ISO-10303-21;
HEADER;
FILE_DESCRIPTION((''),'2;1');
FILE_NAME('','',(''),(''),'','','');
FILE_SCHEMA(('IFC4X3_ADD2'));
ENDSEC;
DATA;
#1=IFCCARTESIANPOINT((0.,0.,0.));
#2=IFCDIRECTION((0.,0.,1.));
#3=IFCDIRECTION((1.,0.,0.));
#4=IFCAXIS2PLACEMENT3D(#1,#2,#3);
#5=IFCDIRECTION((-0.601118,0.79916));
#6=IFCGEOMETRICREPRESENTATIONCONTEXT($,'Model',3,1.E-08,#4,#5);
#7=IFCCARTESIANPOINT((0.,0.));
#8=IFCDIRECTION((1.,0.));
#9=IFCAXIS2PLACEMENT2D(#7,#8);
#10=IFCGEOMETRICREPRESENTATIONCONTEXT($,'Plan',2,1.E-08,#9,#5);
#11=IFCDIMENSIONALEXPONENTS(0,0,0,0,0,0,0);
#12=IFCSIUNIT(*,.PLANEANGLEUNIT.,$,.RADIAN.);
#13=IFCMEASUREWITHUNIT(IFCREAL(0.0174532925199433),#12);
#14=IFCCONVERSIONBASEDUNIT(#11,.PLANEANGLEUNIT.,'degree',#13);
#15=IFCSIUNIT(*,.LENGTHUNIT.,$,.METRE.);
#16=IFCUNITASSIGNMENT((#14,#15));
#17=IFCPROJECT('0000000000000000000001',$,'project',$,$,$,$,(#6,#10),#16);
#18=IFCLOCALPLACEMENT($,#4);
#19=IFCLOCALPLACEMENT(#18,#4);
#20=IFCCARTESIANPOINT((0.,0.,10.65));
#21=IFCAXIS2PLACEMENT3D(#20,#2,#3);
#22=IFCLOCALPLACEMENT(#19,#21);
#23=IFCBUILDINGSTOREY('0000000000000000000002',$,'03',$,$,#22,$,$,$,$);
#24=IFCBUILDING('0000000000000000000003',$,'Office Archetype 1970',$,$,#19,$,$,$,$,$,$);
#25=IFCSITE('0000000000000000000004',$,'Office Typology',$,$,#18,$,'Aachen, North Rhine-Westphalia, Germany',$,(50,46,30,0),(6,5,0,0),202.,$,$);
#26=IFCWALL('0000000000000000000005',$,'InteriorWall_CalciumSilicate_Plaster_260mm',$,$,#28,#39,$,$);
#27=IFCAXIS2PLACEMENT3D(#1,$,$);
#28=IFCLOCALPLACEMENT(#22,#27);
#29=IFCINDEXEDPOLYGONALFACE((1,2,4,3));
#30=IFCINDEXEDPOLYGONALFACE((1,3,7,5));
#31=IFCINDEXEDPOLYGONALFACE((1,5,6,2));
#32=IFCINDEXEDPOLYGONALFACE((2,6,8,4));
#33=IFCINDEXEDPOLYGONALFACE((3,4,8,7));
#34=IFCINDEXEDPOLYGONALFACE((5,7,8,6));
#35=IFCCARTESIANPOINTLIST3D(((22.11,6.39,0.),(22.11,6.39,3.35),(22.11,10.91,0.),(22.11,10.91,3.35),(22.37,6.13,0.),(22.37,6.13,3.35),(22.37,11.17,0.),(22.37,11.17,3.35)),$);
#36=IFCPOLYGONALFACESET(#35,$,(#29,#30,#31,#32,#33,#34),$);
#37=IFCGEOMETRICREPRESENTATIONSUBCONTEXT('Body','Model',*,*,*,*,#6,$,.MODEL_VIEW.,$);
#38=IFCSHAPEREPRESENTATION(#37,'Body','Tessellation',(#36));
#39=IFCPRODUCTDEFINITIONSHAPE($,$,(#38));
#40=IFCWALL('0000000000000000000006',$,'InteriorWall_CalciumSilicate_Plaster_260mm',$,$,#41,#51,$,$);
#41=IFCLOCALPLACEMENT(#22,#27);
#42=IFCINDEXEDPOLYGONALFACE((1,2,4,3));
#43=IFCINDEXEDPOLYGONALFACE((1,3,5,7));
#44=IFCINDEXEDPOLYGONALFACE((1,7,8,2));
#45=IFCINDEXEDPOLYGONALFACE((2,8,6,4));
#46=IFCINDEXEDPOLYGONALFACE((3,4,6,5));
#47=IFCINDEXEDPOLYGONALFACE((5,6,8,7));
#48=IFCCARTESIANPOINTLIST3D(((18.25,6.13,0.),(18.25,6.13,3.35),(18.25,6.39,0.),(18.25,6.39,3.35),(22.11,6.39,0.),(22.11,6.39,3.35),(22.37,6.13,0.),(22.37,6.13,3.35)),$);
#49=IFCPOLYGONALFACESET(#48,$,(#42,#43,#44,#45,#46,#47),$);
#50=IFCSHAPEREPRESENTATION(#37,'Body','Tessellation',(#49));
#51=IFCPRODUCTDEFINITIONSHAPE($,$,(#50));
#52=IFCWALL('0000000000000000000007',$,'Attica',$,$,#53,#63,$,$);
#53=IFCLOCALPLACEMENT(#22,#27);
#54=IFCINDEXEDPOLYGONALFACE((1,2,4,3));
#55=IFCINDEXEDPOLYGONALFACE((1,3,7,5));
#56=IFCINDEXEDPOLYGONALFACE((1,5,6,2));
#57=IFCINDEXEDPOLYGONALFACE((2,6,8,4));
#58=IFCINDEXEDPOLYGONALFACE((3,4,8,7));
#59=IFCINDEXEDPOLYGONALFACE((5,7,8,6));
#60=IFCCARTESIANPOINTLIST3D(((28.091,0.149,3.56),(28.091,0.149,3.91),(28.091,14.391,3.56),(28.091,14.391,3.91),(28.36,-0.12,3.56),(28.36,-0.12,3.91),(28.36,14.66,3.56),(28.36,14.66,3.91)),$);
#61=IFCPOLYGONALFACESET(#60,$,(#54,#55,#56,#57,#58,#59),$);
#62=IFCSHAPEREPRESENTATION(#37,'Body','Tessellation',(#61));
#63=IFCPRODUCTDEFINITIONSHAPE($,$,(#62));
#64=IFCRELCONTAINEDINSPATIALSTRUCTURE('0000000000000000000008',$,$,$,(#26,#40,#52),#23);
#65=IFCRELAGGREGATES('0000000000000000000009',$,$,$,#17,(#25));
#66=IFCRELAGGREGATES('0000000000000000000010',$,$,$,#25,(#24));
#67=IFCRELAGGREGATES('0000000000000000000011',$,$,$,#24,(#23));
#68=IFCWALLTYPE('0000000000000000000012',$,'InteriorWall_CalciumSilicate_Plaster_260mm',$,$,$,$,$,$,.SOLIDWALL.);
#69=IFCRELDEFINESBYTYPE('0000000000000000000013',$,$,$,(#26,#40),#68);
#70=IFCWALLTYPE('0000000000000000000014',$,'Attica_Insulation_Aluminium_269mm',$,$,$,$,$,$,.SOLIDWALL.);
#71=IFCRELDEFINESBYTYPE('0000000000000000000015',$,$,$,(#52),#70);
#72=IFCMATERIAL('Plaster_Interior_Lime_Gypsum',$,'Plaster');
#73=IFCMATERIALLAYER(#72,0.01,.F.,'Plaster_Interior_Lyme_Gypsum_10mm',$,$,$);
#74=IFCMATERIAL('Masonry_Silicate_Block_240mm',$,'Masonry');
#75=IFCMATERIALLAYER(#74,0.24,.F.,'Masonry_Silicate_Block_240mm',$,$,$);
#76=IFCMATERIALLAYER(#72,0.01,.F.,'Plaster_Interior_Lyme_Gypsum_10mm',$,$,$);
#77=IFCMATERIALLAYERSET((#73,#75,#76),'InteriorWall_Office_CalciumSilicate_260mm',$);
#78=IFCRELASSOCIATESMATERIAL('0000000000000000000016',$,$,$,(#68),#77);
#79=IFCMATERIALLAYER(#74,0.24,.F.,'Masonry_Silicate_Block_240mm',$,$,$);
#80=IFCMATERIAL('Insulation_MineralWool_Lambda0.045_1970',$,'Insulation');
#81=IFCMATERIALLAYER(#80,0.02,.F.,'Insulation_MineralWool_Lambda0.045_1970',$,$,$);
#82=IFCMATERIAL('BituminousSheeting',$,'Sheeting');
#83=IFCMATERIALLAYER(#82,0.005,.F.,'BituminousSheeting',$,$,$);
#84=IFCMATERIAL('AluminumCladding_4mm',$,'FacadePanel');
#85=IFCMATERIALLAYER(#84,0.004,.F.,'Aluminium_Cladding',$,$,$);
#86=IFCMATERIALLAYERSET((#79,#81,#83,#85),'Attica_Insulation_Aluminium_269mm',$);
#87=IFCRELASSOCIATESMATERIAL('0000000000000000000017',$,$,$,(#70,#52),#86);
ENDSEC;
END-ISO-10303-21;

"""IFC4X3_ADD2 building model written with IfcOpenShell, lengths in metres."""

from ifc_helpers import new_model, entity, si_unit, converted_unit, direction, frame, origin_with_axes, origin_2d_with_axis, place, context, subcontext, project, spatial, line, indexed_curve, outline, extrude, material, layer, layer_set, layer_usage, type_object, element, save


model = new_model("IFC4X3_ADD2")

# Units and contexts
model_context = context("Model", 3, precision=1e-08, world=origin_with_axes(), true_north=direction((-0.601118, 0.79916)))
plan_context = context("Plan", 2, precision=1e-08, world=origin_2d_with_axis(), true_north=direction((-0.601118, 0.79916)))
body_context = subcontext(model_context, "Body", "Model", "MODEL_VIEW")
ifc_project = project(units=[converted_unit("PLANEANGLEUNIT", "degree", entity("IfcReal", 0.0174532925199433), si_unit("PLANEANGLEUNIT", "RADIAN"), dimensions=[0, 0, 0, 0, 0, 0, 0]), si_unit("LENGTHUNIT", "METRE")], contexts=[model_context, plan_context])

# Site, building, storey
site_placement = place(None, origin_with_axes())
site = spatial("IfcSite", under=ifc_project, at=site_placement, Name="Office Typology", LongName="Aachen, North Rhine-Westphalia, Germany", RefLatitude=(50, 46, 30, 0), RefLongitude=(6, 5, 0, 0), RefElevation=202.0)
building_placement = place(site_placement, origin_with_axes())
building = spatial("IfcBuilding", under=site, at=building_placement, Name="Office Archetype 1970")
storey_placement = place(building_placement, frame((0.0, 0.0, 10.65), z_axis=(0.0, 0.0, 1.0), x_axis=(1.0, 0.0, 0.0)))
storey = spatial("IfcBuildingStorey", under=building, at=storey_placement, Name="03")

# Shared definitions
ifc_material_1 = material(Name="Plaster_Interior_Lime_Gypsum", Category="Plaster")
ifc_layer_1 = layer(ifc_material_1, 0.01, ventilated=False, Name="Plaster_Interior_Lyme_Gypsum_10mm")
ifc_material_2 = material(Name="Masonry_Silicate_Block_240mm", Category="Masonry")
ifc_layer_2 = layer(ifc_material_2, 0.24, ventilated=False, Name="Masonry_Silicate_Block_240mm")
ifc_layer_3 = layer(ifc_material_1, 0.01, ventilated=False, Name="Plaster_Interior_Lyme_Gypsum_10mm")
ifc_layer_set_1 = layer_set([ifc_layer_1, ifc_layer_2, ifc_layer_3], Name="InteriorWall_Office_CalciumSilicate_260mm")
wall_type_1 = type_object("IfcWallType", Name="InteriorWall_CalciumSilicate_Plaster_260mm", PredefinedType="SOLIDWALL", material=ifc_layer_set_1)

# Walls
wall_1_placement = place(storey_placement, frame((22.37, 6.13, 0.0), z_axis=(0.0, 0.0, 1.0), x_axis=(0.0, 1.0, 0.0)))
element("IfcWall", 1, at=wall_1_placement, inside=storey, type_object=wall_type_1, Name="InteriorWall_CalciumSilicate_Plaster_260mm", context=body_context, shape_type="SweptSolid", body=[
    extrude(outline(indexed_curve([(0.0, 0.0), (0.26, 0.26), (4.78, 0.26), (5.04, 0.0)], segments=[line(1, 2, 3, 4, 1)])), origin_with_axes(), (0.0, 0.0, 1.0), 3.35),
])
wall_2_placement = place(storey_placement, frame((18.25, 6.13, 0.0), z_axis=(0.0, 0.0, 1.0), x_axis=(1.0, 0.0, 0.0)))
element("IfcWall", 2, at=wall_2_placement, inside=storey, type_object=wall_type_1, Name="InteriorWall_CalciumSilicate_Plaster_260mm", context=body_context, shape_type="SweptSolid", body=[
    extrude(outline(indexed_curve([(0.0, 0.0), (0.0, 0.26), (3.86, 0.26), (4.12, 0.0)], segments=[line(1, 2, 3, 4, 1)])), origin_with_axes(), (0.0, 0.0, 1.0), 3.35),
])

# Shared definitions
ifc_material_3 = material(Name="Insulation_MineralWool_Lambda0.045_1970", Category="Insulation")

# Wall
ifc_layer_4 = layer(ifc_material_2, 0.24, ventilated=False, Name="Masonry_Silicate_Block_240mm")
ifc_layer_5 = layer(ifc_material_3, 0.02, ventilated=False, Name="Insulation_MineralWool_Lambda0.045_1970")
ifc_material_4 = material(Name="BituminousSheeting", Category="Sheeting")
ifc_layer_6 = layer(ifc_material_4, 0.005, ventilated=False, Name="BituminousSheeting")
ifc_material_5 = material(Name="AluminumCladding_4mm", Category="FacadePanel")
ifc_layer_7 = layer(ifc_material_5, 0.004, ventilated=False, Name="Aluminium_Cladding")
ifc_layer_set_2 = layer_set([ifc_layer_4, ifc_layer_5, ifc_layer_6, ifc_layer_7], Name="Attica_Insulation_Aluminium_269mm")
ifc_layer_usage_1 = layer_usage(ifc_layer_set_2, "AXIS2", "POSITIVE", 0.0)
wall_type_2 = type_object("IfcWallType", Name="Attica_Insulation_Aluminium_269mm", PredefinedType="SOLIDWALL", material=ifc_layer_set_2)
wall_3_placement = place(storey_placement, frame((28.36, -0.12, 3.56), z_axis=(0.0, 0.0, 1.0), x_axis=(0.0, 1.0, 0.0)))
element("IfcWall", 3, at=wall_3_placement, inside=storey, type_object=wall_type_2, material=ifc_layer_usage_1, Name="Attica", context=body_context, shape_type="SweptSolid", body=[
    extrude(outline(indexed_curve([(0.0, 0.0), (0.269, 0.269), (14.511, 0.269), (14.78, 0.0)], segments=[line(1, 2, 3, 4, 1)])), origin_with_axes(), (0.0, 0.0, 1.0), 0.35),
])

save(model, "model.ifc")
